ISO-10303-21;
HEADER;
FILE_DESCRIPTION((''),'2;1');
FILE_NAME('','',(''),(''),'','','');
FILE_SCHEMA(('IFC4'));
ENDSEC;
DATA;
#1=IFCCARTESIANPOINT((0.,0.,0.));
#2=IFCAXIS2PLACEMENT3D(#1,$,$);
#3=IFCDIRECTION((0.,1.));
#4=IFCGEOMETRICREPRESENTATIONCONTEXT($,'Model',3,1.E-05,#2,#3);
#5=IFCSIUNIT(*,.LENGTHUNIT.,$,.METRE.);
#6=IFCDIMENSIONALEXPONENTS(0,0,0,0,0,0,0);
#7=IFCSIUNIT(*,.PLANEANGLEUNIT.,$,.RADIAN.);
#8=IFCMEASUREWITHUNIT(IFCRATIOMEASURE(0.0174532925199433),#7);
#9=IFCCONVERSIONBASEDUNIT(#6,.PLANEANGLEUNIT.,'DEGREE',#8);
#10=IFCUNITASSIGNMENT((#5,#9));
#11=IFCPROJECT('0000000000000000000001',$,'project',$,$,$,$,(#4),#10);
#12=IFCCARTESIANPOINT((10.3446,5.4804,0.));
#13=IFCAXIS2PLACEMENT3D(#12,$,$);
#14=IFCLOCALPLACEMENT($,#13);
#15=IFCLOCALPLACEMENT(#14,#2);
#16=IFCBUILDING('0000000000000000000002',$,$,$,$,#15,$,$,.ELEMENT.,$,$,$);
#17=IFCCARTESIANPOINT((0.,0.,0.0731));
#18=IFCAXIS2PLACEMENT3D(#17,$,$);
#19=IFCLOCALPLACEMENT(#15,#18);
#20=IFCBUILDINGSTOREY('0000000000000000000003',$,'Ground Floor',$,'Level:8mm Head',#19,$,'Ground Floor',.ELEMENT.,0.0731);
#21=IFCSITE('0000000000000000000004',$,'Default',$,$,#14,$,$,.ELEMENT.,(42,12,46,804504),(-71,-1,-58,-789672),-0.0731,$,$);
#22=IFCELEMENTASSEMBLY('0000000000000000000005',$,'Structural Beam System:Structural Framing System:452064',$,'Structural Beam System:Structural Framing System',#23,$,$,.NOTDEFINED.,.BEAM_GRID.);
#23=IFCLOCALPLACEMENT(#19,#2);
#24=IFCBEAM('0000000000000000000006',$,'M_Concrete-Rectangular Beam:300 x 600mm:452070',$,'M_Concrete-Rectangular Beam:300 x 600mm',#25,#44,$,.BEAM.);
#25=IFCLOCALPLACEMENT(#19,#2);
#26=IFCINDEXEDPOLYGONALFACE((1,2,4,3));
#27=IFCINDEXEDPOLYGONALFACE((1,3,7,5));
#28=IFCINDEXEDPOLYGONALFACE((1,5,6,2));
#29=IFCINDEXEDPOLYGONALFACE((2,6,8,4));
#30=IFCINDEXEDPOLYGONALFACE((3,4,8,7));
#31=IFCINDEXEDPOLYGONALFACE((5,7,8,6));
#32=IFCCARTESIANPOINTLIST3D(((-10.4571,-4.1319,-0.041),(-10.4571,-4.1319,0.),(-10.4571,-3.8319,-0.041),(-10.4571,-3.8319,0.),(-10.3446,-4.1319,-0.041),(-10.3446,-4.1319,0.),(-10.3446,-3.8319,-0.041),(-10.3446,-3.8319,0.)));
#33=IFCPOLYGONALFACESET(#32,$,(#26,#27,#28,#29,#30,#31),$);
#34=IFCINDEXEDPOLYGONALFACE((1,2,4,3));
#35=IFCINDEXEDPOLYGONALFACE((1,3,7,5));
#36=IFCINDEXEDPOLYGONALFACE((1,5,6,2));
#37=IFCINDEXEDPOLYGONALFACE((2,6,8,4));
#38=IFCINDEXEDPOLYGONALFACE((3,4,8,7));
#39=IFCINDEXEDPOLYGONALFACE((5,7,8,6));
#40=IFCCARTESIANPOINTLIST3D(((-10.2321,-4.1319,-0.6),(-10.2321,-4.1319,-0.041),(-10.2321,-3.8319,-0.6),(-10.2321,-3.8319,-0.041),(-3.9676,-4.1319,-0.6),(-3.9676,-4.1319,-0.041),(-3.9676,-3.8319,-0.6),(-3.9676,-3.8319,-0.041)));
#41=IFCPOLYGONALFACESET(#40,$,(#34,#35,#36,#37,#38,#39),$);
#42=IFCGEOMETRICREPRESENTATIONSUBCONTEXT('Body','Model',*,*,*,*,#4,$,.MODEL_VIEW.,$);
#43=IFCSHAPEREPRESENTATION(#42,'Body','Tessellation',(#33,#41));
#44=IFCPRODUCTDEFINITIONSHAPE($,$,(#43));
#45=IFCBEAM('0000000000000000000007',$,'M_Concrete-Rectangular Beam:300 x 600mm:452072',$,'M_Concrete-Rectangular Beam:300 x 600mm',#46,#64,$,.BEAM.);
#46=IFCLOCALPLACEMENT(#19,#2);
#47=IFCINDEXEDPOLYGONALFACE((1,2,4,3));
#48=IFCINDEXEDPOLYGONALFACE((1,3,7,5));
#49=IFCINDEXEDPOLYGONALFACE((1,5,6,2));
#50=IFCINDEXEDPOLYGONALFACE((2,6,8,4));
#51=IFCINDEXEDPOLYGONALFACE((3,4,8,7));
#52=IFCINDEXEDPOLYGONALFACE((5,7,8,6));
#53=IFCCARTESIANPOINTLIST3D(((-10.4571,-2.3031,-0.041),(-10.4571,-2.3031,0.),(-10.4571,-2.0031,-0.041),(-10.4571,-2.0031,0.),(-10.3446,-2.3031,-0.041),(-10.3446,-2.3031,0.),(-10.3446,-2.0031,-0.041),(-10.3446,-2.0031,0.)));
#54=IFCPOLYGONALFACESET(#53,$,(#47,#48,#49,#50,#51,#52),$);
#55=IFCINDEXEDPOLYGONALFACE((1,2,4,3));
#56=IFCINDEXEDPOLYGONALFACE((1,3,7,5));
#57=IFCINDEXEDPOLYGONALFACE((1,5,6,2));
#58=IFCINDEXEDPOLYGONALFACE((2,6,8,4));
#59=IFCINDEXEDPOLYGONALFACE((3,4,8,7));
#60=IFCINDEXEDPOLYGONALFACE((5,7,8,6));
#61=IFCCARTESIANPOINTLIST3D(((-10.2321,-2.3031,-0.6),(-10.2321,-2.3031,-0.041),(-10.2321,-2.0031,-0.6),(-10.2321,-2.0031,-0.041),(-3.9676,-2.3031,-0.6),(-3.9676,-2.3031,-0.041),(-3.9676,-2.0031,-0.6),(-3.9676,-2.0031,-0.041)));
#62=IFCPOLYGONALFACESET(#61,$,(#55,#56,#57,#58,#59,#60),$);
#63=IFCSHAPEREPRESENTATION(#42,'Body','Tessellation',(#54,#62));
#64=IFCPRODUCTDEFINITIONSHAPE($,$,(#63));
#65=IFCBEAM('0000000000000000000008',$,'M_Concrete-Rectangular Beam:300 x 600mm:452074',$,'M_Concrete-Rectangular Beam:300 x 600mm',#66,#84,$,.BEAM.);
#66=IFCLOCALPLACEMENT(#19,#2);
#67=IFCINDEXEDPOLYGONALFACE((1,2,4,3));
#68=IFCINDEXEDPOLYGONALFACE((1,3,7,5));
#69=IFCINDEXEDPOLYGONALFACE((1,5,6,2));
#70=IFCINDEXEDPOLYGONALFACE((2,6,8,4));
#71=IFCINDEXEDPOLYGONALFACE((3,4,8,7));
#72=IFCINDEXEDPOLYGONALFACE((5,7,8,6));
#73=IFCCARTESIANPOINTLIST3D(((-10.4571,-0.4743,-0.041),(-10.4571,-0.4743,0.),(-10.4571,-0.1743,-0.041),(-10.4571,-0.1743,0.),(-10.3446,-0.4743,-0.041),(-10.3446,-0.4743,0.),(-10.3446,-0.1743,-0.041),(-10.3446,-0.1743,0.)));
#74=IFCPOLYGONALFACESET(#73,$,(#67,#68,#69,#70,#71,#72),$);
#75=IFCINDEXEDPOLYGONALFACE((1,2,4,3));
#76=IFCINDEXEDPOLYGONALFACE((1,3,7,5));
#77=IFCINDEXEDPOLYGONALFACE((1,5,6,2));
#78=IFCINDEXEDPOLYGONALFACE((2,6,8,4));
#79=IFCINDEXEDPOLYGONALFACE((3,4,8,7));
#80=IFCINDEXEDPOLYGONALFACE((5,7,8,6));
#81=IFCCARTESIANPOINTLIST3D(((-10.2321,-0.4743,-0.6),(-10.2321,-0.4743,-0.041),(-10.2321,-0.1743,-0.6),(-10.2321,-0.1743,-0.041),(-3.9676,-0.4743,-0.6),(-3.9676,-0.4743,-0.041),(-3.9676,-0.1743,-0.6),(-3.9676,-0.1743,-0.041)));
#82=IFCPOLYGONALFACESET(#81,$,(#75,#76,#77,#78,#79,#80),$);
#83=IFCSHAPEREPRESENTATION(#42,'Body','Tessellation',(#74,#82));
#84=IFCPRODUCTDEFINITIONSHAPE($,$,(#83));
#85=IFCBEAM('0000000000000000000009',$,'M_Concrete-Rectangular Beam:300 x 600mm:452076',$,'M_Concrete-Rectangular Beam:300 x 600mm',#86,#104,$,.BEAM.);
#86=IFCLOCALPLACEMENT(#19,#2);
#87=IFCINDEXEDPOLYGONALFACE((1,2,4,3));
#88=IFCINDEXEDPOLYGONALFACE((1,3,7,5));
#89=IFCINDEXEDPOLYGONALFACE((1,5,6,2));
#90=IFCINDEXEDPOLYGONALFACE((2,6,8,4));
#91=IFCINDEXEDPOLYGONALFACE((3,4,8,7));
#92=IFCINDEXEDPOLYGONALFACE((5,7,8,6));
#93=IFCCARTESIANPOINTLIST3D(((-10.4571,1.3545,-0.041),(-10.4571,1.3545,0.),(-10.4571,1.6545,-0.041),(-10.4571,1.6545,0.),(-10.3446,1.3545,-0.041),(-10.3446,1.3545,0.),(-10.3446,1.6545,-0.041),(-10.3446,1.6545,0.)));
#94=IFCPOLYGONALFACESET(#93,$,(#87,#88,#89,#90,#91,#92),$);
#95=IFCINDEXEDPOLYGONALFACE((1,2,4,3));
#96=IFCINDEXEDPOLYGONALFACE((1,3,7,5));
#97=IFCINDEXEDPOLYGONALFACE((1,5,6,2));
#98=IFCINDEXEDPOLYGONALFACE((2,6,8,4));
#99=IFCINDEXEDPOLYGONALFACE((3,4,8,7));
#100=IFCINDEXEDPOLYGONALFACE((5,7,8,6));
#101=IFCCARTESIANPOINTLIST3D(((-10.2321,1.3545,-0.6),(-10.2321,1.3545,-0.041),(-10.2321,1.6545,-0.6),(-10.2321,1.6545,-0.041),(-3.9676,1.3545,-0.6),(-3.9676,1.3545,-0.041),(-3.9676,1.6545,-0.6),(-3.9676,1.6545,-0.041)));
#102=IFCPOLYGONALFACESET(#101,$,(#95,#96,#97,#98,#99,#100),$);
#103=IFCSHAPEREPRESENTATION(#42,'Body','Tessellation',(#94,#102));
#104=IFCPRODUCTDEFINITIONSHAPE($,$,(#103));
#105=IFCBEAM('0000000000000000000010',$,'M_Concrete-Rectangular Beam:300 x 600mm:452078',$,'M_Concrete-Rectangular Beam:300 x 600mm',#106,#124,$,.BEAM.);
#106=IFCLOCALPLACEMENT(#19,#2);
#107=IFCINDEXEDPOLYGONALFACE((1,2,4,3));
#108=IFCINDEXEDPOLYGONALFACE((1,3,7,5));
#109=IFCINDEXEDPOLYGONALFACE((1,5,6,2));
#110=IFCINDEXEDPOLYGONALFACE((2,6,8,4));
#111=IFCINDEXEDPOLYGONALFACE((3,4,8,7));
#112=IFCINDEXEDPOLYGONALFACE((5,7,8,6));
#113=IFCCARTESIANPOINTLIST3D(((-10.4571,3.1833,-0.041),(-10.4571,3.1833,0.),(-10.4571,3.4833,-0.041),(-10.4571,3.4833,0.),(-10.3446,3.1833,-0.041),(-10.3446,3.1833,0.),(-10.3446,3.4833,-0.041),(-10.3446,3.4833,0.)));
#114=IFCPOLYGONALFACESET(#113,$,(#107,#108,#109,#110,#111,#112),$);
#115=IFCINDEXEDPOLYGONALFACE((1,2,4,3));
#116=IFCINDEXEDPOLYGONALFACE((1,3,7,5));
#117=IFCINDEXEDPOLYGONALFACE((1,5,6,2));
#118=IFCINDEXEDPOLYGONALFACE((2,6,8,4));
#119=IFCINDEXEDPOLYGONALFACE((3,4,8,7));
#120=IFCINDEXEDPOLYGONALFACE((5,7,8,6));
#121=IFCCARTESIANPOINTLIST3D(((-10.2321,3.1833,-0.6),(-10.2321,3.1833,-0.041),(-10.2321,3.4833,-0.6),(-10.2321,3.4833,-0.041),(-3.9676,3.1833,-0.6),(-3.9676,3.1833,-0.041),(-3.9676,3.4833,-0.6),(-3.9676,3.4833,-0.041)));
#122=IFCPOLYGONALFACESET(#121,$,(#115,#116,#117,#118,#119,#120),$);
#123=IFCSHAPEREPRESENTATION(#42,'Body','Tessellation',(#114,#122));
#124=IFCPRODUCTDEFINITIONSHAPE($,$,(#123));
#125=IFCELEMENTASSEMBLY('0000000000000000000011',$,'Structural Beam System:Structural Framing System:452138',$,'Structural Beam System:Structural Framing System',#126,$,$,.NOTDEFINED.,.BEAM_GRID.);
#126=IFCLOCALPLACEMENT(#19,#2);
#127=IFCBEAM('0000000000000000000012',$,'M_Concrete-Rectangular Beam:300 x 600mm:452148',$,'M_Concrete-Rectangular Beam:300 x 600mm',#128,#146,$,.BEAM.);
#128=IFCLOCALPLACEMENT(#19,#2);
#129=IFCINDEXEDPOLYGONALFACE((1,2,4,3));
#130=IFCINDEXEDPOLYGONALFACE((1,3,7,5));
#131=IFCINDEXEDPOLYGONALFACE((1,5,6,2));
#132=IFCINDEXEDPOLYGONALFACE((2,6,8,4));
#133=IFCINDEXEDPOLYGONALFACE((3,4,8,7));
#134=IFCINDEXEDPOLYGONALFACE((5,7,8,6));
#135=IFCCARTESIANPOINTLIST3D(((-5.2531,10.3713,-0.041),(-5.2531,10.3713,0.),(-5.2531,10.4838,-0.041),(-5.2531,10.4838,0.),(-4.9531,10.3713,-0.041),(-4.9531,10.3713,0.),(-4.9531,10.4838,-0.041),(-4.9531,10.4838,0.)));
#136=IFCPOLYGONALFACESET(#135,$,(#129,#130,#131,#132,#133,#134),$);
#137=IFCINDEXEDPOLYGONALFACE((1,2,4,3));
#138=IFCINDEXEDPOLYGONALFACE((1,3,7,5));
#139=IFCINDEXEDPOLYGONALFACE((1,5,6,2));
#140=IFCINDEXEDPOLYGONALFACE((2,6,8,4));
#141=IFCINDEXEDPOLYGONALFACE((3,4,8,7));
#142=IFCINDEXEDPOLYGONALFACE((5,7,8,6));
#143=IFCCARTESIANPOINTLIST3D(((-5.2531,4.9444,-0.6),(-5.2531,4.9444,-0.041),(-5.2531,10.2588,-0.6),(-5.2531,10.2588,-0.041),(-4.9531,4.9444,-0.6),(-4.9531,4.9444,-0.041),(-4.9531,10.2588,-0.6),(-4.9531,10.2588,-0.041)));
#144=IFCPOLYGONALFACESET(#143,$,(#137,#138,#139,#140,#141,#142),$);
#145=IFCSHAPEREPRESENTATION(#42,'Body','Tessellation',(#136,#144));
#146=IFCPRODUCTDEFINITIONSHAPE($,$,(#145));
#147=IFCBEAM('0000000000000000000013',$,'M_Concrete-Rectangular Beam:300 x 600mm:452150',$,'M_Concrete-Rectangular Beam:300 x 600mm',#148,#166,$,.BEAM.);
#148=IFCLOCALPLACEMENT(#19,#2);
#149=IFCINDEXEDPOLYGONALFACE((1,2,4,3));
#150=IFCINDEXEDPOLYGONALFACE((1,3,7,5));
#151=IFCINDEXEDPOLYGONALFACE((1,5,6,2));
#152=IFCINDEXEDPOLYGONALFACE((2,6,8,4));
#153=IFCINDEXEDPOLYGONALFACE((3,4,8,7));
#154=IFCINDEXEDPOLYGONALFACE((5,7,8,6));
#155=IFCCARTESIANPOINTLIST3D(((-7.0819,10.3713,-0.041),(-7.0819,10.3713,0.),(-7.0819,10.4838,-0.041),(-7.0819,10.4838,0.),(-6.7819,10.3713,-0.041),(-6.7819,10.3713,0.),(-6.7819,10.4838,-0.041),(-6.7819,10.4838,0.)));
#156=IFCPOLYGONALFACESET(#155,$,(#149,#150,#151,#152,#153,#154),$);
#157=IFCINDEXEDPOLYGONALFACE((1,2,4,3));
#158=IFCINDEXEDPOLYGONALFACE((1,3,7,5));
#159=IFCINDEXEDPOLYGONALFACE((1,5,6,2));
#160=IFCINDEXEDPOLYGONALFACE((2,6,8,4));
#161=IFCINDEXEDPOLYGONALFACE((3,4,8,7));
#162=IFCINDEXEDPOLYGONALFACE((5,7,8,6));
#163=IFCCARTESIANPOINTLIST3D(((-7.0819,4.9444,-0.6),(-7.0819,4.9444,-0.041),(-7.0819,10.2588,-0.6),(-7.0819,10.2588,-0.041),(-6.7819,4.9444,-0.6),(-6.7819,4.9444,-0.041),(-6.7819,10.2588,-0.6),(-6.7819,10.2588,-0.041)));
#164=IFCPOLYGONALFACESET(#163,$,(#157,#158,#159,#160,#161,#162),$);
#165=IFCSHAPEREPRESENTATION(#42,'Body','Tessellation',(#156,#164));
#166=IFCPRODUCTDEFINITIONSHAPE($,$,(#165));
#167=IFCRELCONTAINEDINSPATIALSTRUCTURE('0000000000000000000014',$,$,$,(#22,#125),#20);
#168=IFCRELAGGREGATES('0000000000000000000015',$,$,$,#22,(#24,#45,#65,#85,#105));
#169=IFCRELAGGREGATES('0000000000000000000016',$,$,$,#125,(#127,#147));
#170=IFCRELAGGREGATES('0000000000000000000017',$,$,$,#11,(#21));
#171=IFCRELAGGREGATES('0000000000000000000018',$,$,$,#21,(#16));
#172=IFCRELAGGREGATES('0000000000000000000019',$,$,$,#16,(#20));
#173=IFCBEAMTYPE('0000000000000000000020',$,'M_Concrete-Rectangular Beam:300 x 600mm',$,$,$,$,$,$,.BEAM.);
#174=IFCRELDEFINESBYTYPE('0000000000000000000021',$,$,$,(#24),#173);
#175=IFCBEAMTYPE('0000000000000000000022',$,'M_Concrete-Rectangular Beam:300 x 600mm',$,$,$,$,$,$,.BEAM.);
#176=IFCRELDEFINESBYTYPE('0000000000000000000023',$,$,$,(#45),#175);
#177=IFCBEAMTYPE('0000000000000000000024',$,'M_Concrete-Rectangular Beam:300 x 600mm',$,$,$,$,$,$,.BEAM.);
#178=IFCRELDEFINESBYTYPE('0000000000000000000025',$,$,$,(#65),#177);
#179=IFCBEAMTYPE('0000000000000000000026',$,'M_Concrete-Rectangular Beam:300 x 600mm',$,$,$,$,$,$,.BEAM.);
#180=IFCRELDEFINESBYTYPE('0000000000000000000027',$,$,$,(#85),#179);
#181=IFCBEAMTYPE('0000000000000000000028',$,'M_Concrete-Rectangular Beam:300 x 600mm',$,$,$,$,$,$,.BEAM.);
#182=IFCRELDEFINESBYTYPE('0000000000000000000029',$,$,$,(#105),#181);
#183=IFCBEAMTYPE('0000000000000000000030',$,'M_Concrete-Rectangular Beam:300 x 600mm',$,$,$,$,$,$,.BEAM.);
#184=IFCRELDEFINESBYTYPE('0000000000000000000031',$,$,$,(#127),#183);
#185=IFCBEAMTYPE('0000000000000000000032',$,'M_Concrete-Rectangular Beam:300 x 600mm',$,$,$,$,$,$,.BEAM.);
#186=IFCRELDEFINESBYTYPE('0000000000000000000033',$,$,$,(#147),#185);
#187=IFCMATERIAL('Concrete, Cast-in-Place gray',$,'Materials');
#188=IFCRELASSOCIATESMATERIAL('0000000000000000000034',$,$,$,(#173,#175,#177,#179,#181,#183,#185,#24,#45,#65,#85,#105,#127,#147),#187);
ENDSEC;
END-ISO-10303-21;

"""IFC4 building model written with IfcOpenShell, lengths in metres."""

from ifc_helpers import new_model, entity, si_unit, converted_unit, direction, frame, frame_2d, origin, place, context, subcontext, project, spatial, rectangle, extrude, source, transform, mapped, material, material_profile, profile_set, profile_usage, type_object, type_shapes, element, aggregate, save


model = new_model("IFC4")

# Units and contexts
model_context = context("Model", 3, precision=1e-05, world=origin(), true_north=direction((0.0, 1.0)))
body_context = subcontext(model_context, "Body", "Model", "MODEL_VIEW")
ifc_project = project(units=[si_unit("LENGTHUNIT", "METRE"), converted_unit("PLANEANGLEUNIT", "DEGREE", entity("IfcRatioMeasure", 0.0174532925199433), si_unit("PLANEANGLEUNIT", "RADIAN"), dimensions=[0, 0, 0, 0, 0, 0, 0])], contexts=[model_context])

# Site, building, storey
site_placement = place(None, frame((10.3446, 5.4804, 0.0)))
site = spatial("IfcSite", under=ifc_project, at=site_placement, Name="Default", CompositionType="ELEMENT", RefLatitude=(42, 12, 46, 804504), RefLongitude=(-71, -1, -58, -789672), RefElevation=-0.0731)
building_placement = place(site_placement, origin())
building = spatial("IfcBuilding", under=site, at=building_placement, CompositionType="ELEMENT")
storey_placement = place(building_placement, frame((0.0, 0.0, 0.0731)))
storey = spatial("IfcBuildingStorey", under=building, at=storey_placement, Name="Ground Floor", ObjectType="Level:8mm Head", LongName="Ground Floor", CompositionType="ELEMENT", Elevation=0.0731)

# Element assemblies, beams
assembly_1_placement = place(storey_placement, origin())
assembly_1 = element("IfcElementAssembly", 1, at=assembly_1_placement, inside=storey, Name="Structural Beam System:Structural Framing System:452064", ObjectType="Structural Beam System:Structural Framing System", AssemblyPlace="NOTDEFINED", PredefinedType="BEAM_GRID")
ifc_material_1 = material(Name="Concrete, Cast-in-Place gray", Category="Materials")
ifc_material_profile = material_profile(ifc_material_1, rectangle(XDim=0.559, YDim=0.3, at=frame_2d((0.0, 0.0), x_axis=(1.0, 0.0))), Name="300 x 600mm")
ifc_profile_set = profile_set([ifc_material_profile], Name="300 x 600mm")
ifc_profile_usage_1 = profile_usage(ifc_profile_set, cardinal=8)
beam_type_1 = type_object("IfcBeamType", Name="M_Concrete-Rectangular Beam:300 x 600mm", PredefinedType="BEAM", material=ifc_profile_set)
shared_shape_1 = source(origin(), body_context, "Body", "SweptSolid", [
    extrude(rectangle(XDim=0.041, YDim=0.3, at=frame_2d((0.0, 0.0), x_axis=(1.0, 0.0))), frame((-10.4571, -3.9819, 0.0526), z_axis=(1.0, 0.0, 0.0), x_axis=(0.0, 0.0, -1.0)), (0.0, 0.0, 1.0), 0.1125),
    extrude(rectangle(XDim=0.559, YDim=0.3, at=frame_2d((0.0, 0.0), x_axis=(1.0, 0.0))), frame((-10.2321, -3.9819, -0.2474), z_axis=(1.0, 0.0, 0.0), x_axis=(0.0, 0.0, -1.0)), (0.0, 0.0, 1.0), 6.2645),
])
type_shapes(beam_type_1, [shared_shape_1])
beam_1_placement = place(assembly_1_placement, frame((0.0, 0.0, -0.0731)))
beam_1 = element("IfcBeam", 2, at=beam_1_placement, type_object=beam_type_1, material=ifc_profile_usage_1, Name="M_Concrete-Rectangular Beam:300 x 600mm:452070", ObjectType="M_Concrete-Rectangular Beam:300 x 600mm", PredefinedType="BEAM", context=body_context, shape_type="MappedRepresentation", body=[
    mapped(shared_shape_1, transform((0.0, 0.0, 0.0), scale=1.0)),
])
ifc_profile_usage_2 = profile_usage(ifc_profile_set, cardinal=8)
beam_type_2 = type_object("IfcBeamType", Name="M_Concrete-Rectangular Beam:300 x 600mm", PredefinedType="BEAM", material=ifc_profile_set)
shared_shape_2 = source(origin(), body_context, "Body", "SweptSolid", [
    extrude(rectangle(XDim=0.041, YDim=0.3, at=frame_2d((0.0, 0.0), x_axis=(1.0, 0.0))), frame((-10.4571, -2.1531, 0.0526), z_axis=(1.0, 0.0, 0.0), x_axis=(0.0, 0.0, -1.0)), (0.0, 0.0, 1.0), 0.1125),
    extrude(rectangle(XDim=0.559, YDim=0.3, at=frame_2d((0.0, 0.0), x_axis=(1.0, 0.0))), frame((-10.2321, -2.1531, -0.2474), z_axis=(1.0, 0.0, 0.0), x_axis=(0.0, 0.0, -1.0)), (0.0, 0.0, 1.0), 6.2645),
])
type_shapes(beam_type_2, [shared_shape_2])
beam_2_placement = place(assembly_1_placement, frame((0.0, 0.0, -0.0731)))
beam_2 = element("IfcBeam", 3, at=beam_2_placement, type_object=beam_type_2, material=ifc_profile_usage_2, Name="M_Concrete-Rectangular Beam:300 x 600mm:452072", ObjectType="M_Concrete-Rectangular Beam:300 x 600mm", PredefinedType="BEAM", context=body_context, shape_type="MappedRepresentation", body=[
    mapped(shared_shape_2, transform((0.0, 0.0, 0.0), scale=1.0)),
])
ifc_profile_usage_3 = profile_usage(ifc_profile_set, cardinal=8)
beam_type_3 = type_object("IfcBeamType", Name="M_Concrete-Rectangular Beam:300 x 600mm", PredefinedType="BEAM", material=ifc_profile_set)
shared_shape_3 = source(origin(), body_context, "Body", "SweptSolid", [
    extrude(rectangle(XDim=0.041, YDim=0.3, at=frame_2d((0.0, 0.0), x_axis=(1.0, 0.0))), frame((-10.4571, -0.3243, 0.0526), z_axis=(1.0, 0.0, 0.0), x_axis=(0.0, 0.0, -1.0)), (0.0, 0.0, 1.0), 0.1125),
    extrude(rectangle(XDim=0.559, YDim=0.3, at=frame_2d((0.0, 0.0), x_axis=(1.0, 0.0))), frame((-10.2321, -0.3243, -0.2474), z_axis=(1.0, 0.0, 0.0), x_axis=(0.0, 0.0, -1.0)), (0.0, 0.0, 1.0), 6.2645),
])
type_shapes(beam_type_3, [shared_shape_3])
beam_3_placement = place(assembly_1_placement, frame((0.0, 0.0, -0.0731)))
beam_3 = element("IfcBeam", 4, at=beam_3_placement, type_object=beam_type_3, material=ifc_profile_usage_3, Name="M_Concrete-Rectangular Beam:300 x 600mm:452074", ObjectType="M_Concrete-Rectangular Beam:300 x 600mm", PredefinedType="BEAM", context=body_context, shape_type="MappedRepresentation", body=[
    mapped(shared_shape_3, transform((0.0, 0.0, 0.0), scale=1.0)),
])
ifc_profile_usage_4 = profile_usage(ifc_profile_set, cardinal=8)
beam_type_4 = type_object("IfcBeamType", Name="M_Concrete-Rectangular Beam:300 x 600mm", PredefinedType="BEAM", material=ifc_profile_set)
shared_shape_4 = source(origin(), body_context, "Body", "SweptSolid", [
    extrude(rectangle(XDim=0.041, YDim=0.3, at=frame_2d((0.0, 0.0), x_axis=(1.0, 0.0))), frame((-10.4571, 1.5045, 0.0526), z_axis=(1.0, 0.0, 0.0), x_axis=(0.0, 0.0, -1.0)), (0.0, 0.0, 1.0), 0.1125),
    extrude(rectangle(XDim=0.559, YDim=0.3, at=frame_2d((0.0, 0.0), x_axis=(1.0, 0.0))), frame((-10.2321, 1.5045, -0.2474), z_axis=(1.0, 0.0, 0.0), x_axis=(0.0, 0.0, -1.0)), (0.0, 0.0, 1.0), 6.2645),
])
type_shapes(beam_type_4, [shared_shape_4])
beam_4_placement = place(assembly_1_placement, frame((0.0, 0.0, -0.0731)))
beam_4 = element("IfcBeam", 5, at=beam_4_placement, type_object=beam_type_4, material=ifc_profile_usage_4, Name="M_Concrete-Rectangular Beam:300 x 600mm:452076", ObjectType="M_Concrete-Rectangular Beam:300 x 600mm", PredefinedType="BEAM", context=body_context, shape_type="MappedRepresentation", body=[
    mapped(shared_shape_4, transform((0.0, 0.0, 0.0), scale=1.0)),
])
ifc_profile_usage_5 = profile_usage(ifc_profile_set, cardinal=8)
beam_type_5 = type_object("IfcBeamType", Name="M_Concrete-Rectangular Beam:300 x 600mm", PredefinedType="BEAM", material=ifc_profile_set)
shared_shape_5 = source(origin(), body_context, "Body", "SweptSolid", [
    extrude(rectangle(XDim=0.041, YDim=0.3, at=frame_2d((0.0, 0.0), x_axis=(1.0, 0.0))), frame((-10.4571, 3.3333, 0.0526), z_axis=(1.0, 0.0, 0.0), x_axis=(0.0, 0.0, -1.0)), (0.0, 0.0, 1.0), 0.1125),
    extrude(rectangle(XDim=0.559, YDim=0.3, at=frame_2d((0.0, 0.0), x_axis=(1.0, 0.0))), frame((-10.2321, 3.3333, -0.2474), z_axis=(1.0, 0.0, 0.0), x_axis=(0.0, 0.0, -1.0)), (0.0, 0.0, 1.0), 6.2645),
])
type_shapes(beam_type_5, [shared_shape_5])
beam_5_placement = place(assembly_1_placement, frame((0.0, 0.0, -0.0731)))
beam_5 = element("IfcBeam", 6, at=beam_5_placement, type_object=beam_type_5, material=ifc_profile_usage_5, Name="M_Concrete-Rectangular Beam:300 x 600mm:452078", ObjectType="M_Concrete-Rectangular Beam:300 x 600mm", PredefinedType="BEAM", context=body_context, shape_type="MappedRepresentation", body=[
    mapped(shared_shape_5, transform((0.0, 0.0, 0.0), scale=1.0)),
])
aggregate(assembly_1, [beam_1, beam_2, beam_3, beam_4, beam_5])
assembly_2_placement = place(storey_placement, origin())
assembly_2 = element("IfcElementAssembly", 7, at=assembly_2_placement, inside=storey, Name="Structural Beam System:Structural Framing System:452138", ObjectType="Structural Beam System:Structural Framing System", AssemblyPlace="NOTDEFINED", PredefinedType="BEAM_GRID")
ifc_profile_usage_6 = profile_usage(ifc_profile_set, cardinal=8)
beam_type_6 = type_object("IfcBeamType", Name="M_Concrete-Rectangular Beam:300 x 600mm", PredefinedType="BEAM", material=ifc_profile_set)
shared_shape_6 = source(origin(), body_context, "Body", "SweptSolid", [
    extrude(rectangle(XDim=0.041, YDim=0.3, at=frame_2d((0.0, 0.0), x_axis=(0.0, 1.0))), frame((-5.1031, 10.4838, 0.0526), z_axis=(0.0, -1.0, 0.0), x_axis=(-1.0, 0.0, 0.0)), (0.0, 0.0, 1.0), 0.1125),
    extrude(rectangle(XDim=0.559, YDim=0.3, at=frame_2d((0.0, 0.0), x_axis=(0.0, 1.0))), frame((-5.1031, 10.2588, -0.2474), z_axis=(0.0, -1.0, 0.0), x_axis=(-1.0, 0.0, 0.0)), (0.0, 0.0, 1.0), 5.3144),
])
type_shapes(beam_type_6, [shared_shape_6])
beam_6_placement = place(assembly_2_placement, frame((0.0, 0.0, -0.0731)))
beam_6 = element("IfcBeam", 8, at=beam_6_placement, type_object=beam_type_6, material=ifc_profile_usage_6, Name="M_Concrete-Rectangular Beam:300 x 600mm:452148", ObjectType="M_Concrete-Rectangular Beam:300 x 600mm", PredefinedType="BEAM", context=body_context, shape_type="MappedRepresentation", body=[
    mapped(shared_shape_6, transform((0.0, 0.0, 0.0), scale=1.0)),
])
ifc_profile_usage_7 = profile_usage(ifc_profile_set, cardinal=8)
beam_type_7 = type_object("IfcBeamType", Name="M_Concrete-Rectangular Beam:300 x 600mm", PredefinedType="BEAM", material=ifc_profile_set)
shared_shape_7 = source(origin(), body_context, "Body", "SweptSolid", [
    extrude(rectangle(XDim=0.041, YDim=0.3, at=frame_2d((0.0, 0.0), x_axis=(0.0, 1.0))), frame((-6.9319, 10.4838, 0.0526), z_axis=(0.0, -1.0, 0.0), x_axis=(-1.0, 0.0, 0.0)), (0.0, 0.0, 1.0), 0.1125),
    extrude(rectangle(XDim=0.559, YDim=0.3, at=frame_2d((0.0, 0.0), x_axis=(0.0, 1.0))), frame((-6.9319, 10.2588, -0.2474), z_axis=(0.0, -1.0, 0.0), x_axis=(-1.0, 0.0, 0.0)), (0.0, 0.0, 1.0), 5.3144),
])
type_shapes(beam_type_7, [shared_shape_7])
beam_7_placement = place(assembly_2_placement, frame((0.0, 0.0, -0.0731)))
beam_7 = element("IfcBeam", 9, at=beam_7_placement, type_object=beam_type_7, material=ifc_profile_usage_7, Name="M_Concrete-Rectangular Beam:300 x 600mm:452150", ObjectType="M_Concrete-Rectangular Beam:300 x 600mm", PredefinedType="BEAM", context=body_context, shape_type="MappedRepresentation", body=[
    mapped(shared_shape_7, transform((0.0, 0.0, 0.0), scale=1.0)),
])
aggregate(assembly_2, [beam_6, beam_7])

save(model, "model.ifc")
